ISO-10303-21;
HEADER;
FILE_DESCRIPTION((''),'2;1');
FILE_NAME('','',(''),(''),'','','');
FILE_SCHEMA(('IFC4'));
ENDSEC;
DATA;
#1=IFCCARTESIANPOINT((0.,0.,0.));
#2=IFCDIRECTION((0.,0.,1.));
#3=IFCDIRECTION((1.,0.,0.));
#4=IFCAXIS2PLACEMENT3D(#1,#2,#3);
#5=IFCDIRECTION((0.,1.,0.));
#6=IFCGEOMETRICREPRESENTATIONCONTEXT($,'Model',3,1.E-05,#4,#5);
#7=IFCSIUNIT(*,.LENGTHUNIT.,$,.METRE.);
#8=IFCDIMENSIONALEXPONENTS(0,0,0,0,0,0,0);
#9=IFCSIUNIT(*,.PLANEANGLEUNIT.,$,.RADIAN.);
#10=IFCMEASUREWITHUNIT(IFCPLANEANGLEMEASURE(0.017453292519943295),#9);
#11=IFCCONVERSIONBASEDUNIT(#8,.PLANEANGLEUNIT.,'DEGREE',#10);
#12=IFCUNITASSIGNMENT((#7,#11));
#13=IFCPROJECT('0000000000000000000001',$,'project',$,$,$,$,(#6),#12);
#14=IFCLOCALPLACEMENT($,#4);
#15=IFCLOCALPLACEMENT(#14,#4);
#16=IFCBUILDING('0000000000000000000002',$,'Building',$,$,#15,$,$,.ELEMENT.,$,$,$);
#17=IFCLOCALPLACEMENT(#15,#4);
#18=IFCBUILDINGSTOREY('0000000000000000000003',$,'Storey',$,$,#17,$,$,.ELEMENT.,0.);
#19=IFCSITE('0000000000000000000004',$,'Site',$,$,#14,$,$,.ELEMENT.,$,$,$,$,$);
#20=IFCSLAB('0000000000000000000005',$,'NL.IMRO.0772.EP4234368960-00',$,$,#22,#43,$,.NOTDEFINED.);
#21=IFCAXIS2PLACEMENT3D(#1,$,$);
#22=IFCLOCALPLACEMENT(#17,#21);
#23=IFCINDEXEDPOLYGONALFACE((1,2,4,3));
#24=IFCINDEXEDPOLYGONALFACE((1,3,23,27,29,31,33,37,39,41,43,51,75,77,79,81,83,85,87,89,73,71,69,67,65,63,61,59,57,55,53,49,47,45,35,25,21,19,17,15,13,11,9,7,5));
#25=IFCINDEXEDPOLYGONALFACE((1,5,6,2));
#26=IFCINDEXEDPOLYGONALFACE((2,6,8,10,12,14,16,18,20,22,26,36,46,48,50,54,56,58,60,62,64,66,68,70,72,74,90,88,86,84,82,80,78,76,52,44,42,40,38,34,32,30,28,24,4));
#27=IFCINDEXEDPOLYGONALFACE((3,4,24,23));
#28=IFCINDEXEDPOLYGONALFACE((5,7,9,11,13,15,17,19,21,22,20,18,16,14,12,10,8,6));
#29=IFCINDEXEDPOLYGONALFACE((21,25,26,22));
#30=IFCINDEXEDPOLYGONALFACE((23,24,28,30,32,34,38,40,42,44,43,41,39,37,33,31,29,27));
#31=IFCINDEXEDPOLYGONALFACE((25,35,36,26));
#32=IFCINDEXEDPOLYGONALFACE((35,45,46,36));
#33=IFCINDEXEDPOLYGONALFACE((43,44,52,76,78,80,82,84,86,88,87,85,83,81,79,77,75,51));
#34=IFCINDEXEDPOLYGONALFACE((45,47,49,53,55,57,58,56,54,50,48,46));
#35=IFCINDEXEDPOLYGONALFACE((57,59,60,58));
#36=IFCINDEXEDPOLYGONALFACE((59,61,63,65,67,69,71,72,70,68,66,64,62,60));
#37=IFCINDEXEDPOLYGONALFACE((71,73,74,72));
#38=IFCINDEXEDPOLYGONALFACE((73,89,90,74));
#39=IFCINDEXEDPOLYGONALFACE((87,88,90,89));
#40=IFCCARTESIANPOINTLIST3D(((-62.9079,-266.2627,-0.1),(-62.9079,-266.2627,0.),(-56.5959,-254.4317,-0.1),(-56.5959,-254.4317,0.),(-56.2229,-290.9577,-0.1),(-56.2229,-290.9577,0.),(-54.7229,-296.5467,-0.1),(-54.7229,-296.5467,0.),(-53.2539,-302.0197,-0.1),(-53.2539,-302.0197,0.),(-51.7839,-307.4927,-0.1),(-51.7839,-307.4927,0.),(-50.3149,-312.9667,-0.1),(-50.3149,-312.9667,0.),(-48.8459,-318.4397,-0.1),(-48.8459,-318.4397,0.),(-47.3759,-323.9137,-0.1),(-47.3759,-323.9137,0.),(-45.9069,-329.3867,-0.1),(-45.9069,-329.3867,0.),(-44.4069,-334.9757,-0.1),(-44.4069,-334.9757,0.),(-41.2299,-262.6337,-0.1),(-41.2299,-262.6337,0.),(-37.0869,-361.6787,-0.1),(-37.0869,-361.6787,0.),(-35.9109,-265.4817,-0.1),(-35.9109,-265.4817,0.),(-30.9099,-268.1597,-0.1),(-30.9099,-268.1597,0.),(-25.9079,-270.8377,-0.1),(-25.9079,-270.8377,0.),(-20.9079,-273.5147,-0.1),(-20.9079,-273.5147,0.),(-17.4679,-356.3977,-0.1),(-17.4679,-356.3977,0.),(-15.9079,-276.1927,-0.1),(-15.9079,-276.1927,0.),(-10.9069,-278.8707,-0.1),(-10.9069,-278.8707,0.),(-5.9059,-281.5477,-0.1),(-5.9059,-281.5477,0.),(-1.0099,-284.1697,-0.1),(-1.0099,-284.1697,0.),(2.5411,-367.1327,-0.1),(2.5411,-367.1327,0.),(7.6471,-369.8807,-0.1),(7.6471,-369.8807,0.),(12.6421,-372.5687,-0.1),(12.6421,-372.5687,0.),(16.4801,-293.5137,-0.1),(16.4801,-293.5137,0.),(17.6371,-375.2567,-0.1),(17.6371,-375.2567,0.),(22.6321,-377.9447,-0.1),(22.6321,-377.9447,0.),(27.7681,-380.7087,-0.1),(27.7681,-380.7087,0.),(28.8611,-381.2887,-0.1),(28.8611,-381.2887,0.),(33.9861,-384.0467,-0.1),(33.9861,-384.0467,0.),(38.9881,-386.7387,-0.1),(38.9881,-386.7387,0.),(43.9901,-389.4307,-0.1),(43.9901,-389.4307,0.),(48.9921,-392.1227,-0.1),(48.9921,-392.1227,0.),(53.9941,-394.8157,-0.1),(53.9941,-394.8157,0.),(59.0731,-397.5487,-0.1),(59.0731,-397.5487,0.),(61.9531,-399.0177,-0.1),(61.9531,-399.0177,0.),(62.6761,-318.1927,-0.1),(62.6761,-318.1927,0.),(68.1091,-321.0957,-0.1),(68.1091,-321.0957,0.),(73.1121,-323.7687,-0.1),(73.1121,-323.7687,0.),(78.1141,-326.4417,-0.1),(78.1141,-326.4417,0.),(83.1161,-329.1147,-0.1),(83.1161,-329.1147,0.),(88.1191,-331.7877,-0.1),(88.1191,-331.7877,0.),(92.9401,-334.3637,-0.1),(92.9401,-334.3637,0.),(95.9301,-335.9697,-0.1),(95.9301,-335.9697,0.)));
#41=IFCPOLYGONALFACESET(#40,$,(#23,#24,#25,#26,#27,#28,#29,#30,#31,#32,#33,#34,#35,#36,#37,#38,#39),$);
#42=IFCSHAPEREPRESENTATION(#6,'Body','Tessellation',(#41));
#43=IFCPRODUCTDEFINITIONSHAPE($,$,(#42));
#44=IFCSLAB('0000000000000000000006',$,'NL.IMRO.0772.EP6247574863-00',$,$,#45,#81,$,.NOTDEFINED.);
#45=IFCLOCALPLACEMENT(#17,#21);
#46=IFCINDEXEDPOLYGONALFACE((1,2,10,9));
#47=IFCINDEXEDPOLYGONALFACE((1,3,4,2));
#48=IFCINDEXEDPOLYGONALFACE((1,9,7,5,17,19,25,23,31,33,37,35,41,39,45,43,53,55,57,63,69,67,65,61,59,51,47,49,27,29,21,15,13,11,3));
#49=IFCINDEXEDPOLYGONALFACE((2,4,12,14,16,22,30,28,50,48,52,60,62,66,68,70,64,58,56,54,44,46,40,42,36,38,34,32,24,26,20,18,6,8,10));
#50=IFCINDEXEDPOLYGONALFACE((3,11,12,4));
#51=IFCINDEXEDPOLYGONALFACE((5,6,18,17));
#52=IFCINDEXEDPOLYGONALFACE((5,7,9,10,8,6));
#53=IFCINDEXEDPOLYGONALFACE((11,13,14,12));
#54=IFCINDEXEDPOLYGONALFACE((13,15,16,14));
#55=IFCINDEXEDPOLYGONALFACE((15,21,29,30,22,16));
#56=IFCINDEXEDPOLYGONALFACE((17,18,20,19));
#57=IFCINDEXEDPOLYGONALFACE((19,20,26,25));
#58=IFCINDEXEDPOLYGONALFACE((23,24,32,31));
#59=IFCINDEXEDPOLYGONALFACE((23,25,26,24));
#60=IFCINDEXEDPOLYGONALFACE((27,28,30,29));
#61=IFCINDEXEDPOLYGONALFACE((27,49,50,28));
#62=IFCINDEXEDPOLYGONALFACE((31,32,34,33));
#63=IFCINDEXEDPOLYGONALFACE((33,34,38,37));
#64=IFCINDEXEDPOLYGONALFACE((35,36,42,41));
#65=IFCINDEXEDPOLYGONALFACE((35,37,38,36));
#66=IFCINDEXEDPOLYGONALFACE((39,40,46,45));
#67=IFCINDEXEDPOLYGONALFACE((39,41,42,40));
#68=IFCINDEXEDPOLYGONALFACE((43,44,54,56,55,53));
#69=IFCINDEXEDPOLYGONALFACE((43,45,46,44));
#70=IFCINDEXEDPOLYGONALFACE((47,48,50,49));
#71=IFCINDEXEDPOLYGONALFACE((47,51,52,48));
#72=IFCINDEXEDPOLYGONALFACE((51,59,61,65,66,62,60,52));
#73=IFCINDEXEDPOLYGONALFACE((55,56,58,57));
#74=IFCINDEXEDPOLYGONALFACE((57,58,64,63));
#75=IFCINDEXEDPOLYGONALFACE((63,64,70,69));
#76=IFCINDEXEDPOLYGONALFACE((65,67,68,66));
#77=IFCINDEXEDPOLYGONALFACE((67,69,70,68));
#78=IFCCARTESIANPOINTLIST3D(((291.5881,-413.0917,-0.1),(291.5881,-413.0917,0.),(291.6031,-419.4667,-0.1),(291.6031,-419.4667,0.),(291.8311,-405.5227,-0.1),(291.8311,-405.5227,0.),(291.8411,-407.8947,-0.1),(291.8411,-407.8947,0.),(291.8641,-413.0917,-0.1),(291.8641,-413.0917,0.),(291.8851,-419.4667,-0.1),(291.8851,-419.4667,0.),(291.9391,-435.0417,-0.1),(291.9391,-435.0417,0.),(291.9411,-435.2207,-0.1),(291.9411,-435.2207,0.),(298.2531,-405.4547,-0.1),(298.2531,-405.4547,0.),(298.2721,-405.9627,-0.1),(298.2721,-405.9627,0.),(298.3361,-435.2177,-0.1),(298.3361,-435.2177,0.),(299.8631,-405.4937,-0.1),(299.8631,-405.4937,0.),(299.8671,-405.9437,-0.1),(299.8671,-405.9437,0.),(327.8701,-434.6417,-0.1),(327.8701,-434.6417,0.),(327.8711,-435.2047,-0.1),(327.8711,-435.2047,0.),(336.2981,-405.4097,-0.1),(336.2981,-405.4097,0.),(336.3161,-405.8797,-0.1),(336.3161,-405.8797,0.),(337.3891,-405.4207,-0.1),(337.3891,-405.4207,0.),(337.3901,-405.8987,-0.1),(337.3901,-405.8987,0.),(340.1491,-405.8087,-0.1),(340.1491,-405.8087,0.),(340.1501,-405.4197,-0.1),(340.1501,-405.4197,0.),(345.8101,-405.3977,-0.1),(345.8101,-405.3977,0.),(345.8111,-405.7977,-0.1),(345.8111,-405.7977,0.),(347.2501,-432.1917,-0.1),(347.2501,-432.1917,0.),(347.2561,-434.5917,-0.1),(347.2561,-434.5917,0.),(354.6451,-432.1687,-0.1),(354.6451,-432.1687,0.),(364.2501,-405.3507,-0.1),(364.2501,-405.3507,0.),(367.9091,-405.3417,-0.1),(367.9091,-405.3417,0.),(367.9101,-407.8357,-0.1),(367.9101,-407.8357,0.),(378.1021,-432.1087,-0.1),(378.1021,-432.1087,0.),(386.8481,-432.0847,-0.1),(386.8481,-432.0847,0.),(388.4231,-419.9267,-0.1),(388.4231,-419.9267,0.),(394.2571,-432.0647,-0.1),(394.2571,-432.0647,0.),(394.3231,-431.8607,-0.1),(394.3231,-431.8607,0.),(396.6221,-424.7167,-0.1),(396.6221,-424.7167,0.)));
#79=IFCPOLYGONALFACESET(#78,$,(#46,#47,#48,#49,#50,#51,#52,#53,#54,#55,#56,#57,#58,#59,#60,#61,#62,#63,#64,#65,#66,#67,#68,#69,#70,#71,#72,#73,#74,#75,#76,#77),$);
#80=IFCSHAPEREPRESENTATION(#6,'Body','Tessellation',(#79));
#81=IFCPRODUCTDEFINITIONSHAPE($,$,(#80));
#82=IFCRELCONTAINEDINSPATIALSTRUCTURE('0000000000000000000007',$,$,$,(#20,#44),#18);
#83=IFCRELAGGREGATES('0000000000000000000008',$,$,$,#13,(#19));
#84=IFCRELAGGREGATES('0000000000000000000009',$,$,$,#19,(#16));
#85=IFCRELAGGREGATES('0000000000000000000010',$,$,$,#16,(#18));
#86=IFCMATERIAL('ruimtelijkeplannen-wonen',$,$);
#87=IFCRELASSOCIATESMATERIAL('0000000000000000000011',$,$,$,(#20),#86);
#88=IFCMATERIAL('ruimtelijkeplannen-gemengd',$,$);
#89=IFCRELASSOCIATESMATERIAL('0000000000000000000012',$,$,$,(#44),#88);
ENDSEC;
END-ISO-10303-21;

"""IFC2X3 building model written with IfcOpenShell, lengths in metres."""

from ifc_helpers import new_model, entity, si_unit, converted_unit, direction, frame, origin_with_axes, place, context, project, spatial, polyline, outline, extrude, material, element, save


model = new_model("IFC2X3")

# Units and contexts
model_context = context("Model", 3, precision=1e-05, world=origin_with_axes(), true_north=direction((0.0, 1.0, 0.0)))
ifc_project = project(units=[si_unit("LENGTHUNIT", "METRE"), converted_unit("PLANEANGLEUNIT", "DEGREE", entity("IfcPlaneAngleMeasure", 0.017453292519943295), si_unit("PLANEANGLEUNIT", "RADIAN"), dimensions=[0, 0, 0, 0, 0, 0, 0])], contexts=[model_context])

# Site, building, storey
site_placement = place(None, origin_with_axes())
site = spatial("IfcSite", under=ifc_project, at=site_placement, Name="Site", CompositionType="ELEMENT")
building_placement = place(site_placement, origin_with_axes())
building = spatial("IfcBuilding", under=site, at=building_placement, Name="Building", CompositionType="ELEMENT")
storey_placement = place(building_placement, origin_with_axes())
storey = spatial("IfcBuildingStorey", under=building, at=storey_placement, Name="Storey", CompositionType="ELEMENT", Elevation=0.0)

# Slabs
ifc_material_1 = material(Name="ruimtelijkeplannen-wonen")
slab_1_placement = place(storey_placement, frame((0.0, 0.0, -0.1), z_axis=(0.0, 0.0, 1.0), x_axis=(1.0, 0.0, 0.0)))
element("IfcSlab", 1, at=slab_1_placement, inside=storey, material=ifc_material_1, Name="NL.IMRO.0772.EP4234368960-00", PredefinedType="NOTDEFINED", context=model_context, shape_type="SweptSolid", body=[
    extrude(outline(polyline([(-62.9079, -266.2627), (-56.5959, -254.4317), (-41.2299, -262.6337), (-35.9109, -265.4817), (-30.9099, -268.1597), (-25.9079, -270.8377), (-20.9079, -273.5147), (-15.9079, -276.1927), (-10.9069, -278.8707), (-5.9059, -281.5477), (-1.0099, -284.1697), (16.4801, -293.5137), (62.6761, -318.1927), (68.1091, -321.0957), (73.1121, -323.7687), (78.1141, -326.4417), (83.1161, -329.1147), (88.1191, -331.7877), (92.9401, -334.3637), (95.9301, -335.9697), (61.9531, -399.0177), (59.0731, -397.5487), (53.9941, -394.8157), (48.9921, -392.1227), (43.9901, -389.4307), (38.9881, -386.7387), (33.9861, -384.0467), (28.8611, -381.2887), (27.7681, -380.7087), (22.6321, -377.9447), (17.6371, -375.2567), (12.6421, -372.5687), (7.6471, -369.8807), (2.5411, -367.1327), (-17.4679, -356.3977), (-37.0869, -361.6787), (-44.4069, -334.9757), (-45.9069, -329.3867), (-47.3759, -323.9137), (-48.8459, -318.4397), (-50.3149, -312.9667), (-51.7839, -307.4927), (-53.2539, -302.0197), (-54.7229, -296.5467), (-56.2229, -290.9577), (-62.9079, -266.2627)])), origin_with_axes(), (0.0, 0.0, 1.0), 0.1),
])
ifc_material_2 = material(Name="ruimtelijkeplannen-gemengd")
slab_2_placement = place(storey_placement, frame((0.0, 0.0, -0.1), z_axis=(0.0, 0.0, 1.0), x_axis=(1.0, 0.0, 0.0)))
element("IfcSlab", 2, at=slab_2_placement, inside=storey, material=ifc_material_2, Name="NL.IMRO.0772.EP6247574863-00", PredefinedType="NOTDEFINED", context=model_context, shape_type="SweptSolid", body=[
    extrude(outline(polyline([(291.9411, -435.2207), (291.9391, -435.0417), (291.8851, -419.4667), (291.6031, -419.4667), (291.5881, -413.0917), (291.8641, -413.0917), (291.8411, -407.8947), (291.8311, -405.5227), (298.2531, -405.4547), (298.2721, -405.9627), (299.8671, -405.9437), (299.8631, -405.4937), (336.2981, -405.4097), (336.3161, -405.8797), (337.3901, -405.8987), (337.3891, -405.4207), (340.1501, -405.4197), (340.1491, -405.8087), (345.8111, -405.7977), (345.8101, -405.3977), (364.2501, -405.3507), (367.9091, -405.3417), (367.9101, -407.8357), (388.4231, -419.9267), (396.6221, -424.7167), (394.3231, -431.8607), (394.2571, -432.0647), (386.8481, -432.0847), (378.1021, -432.1087), (354.6451, -432.1687), (347.2501, -432.1917), (347.2561, -434.5917), (327.8701, -434.6417), (327.8711, -435.2047), (298.3361, -435.2177), (291.9411, -435.2207)])), origin_with_axes(), (0.0, 0.0, 1.0), 0.1),
])

save(model, "model.ifc")
